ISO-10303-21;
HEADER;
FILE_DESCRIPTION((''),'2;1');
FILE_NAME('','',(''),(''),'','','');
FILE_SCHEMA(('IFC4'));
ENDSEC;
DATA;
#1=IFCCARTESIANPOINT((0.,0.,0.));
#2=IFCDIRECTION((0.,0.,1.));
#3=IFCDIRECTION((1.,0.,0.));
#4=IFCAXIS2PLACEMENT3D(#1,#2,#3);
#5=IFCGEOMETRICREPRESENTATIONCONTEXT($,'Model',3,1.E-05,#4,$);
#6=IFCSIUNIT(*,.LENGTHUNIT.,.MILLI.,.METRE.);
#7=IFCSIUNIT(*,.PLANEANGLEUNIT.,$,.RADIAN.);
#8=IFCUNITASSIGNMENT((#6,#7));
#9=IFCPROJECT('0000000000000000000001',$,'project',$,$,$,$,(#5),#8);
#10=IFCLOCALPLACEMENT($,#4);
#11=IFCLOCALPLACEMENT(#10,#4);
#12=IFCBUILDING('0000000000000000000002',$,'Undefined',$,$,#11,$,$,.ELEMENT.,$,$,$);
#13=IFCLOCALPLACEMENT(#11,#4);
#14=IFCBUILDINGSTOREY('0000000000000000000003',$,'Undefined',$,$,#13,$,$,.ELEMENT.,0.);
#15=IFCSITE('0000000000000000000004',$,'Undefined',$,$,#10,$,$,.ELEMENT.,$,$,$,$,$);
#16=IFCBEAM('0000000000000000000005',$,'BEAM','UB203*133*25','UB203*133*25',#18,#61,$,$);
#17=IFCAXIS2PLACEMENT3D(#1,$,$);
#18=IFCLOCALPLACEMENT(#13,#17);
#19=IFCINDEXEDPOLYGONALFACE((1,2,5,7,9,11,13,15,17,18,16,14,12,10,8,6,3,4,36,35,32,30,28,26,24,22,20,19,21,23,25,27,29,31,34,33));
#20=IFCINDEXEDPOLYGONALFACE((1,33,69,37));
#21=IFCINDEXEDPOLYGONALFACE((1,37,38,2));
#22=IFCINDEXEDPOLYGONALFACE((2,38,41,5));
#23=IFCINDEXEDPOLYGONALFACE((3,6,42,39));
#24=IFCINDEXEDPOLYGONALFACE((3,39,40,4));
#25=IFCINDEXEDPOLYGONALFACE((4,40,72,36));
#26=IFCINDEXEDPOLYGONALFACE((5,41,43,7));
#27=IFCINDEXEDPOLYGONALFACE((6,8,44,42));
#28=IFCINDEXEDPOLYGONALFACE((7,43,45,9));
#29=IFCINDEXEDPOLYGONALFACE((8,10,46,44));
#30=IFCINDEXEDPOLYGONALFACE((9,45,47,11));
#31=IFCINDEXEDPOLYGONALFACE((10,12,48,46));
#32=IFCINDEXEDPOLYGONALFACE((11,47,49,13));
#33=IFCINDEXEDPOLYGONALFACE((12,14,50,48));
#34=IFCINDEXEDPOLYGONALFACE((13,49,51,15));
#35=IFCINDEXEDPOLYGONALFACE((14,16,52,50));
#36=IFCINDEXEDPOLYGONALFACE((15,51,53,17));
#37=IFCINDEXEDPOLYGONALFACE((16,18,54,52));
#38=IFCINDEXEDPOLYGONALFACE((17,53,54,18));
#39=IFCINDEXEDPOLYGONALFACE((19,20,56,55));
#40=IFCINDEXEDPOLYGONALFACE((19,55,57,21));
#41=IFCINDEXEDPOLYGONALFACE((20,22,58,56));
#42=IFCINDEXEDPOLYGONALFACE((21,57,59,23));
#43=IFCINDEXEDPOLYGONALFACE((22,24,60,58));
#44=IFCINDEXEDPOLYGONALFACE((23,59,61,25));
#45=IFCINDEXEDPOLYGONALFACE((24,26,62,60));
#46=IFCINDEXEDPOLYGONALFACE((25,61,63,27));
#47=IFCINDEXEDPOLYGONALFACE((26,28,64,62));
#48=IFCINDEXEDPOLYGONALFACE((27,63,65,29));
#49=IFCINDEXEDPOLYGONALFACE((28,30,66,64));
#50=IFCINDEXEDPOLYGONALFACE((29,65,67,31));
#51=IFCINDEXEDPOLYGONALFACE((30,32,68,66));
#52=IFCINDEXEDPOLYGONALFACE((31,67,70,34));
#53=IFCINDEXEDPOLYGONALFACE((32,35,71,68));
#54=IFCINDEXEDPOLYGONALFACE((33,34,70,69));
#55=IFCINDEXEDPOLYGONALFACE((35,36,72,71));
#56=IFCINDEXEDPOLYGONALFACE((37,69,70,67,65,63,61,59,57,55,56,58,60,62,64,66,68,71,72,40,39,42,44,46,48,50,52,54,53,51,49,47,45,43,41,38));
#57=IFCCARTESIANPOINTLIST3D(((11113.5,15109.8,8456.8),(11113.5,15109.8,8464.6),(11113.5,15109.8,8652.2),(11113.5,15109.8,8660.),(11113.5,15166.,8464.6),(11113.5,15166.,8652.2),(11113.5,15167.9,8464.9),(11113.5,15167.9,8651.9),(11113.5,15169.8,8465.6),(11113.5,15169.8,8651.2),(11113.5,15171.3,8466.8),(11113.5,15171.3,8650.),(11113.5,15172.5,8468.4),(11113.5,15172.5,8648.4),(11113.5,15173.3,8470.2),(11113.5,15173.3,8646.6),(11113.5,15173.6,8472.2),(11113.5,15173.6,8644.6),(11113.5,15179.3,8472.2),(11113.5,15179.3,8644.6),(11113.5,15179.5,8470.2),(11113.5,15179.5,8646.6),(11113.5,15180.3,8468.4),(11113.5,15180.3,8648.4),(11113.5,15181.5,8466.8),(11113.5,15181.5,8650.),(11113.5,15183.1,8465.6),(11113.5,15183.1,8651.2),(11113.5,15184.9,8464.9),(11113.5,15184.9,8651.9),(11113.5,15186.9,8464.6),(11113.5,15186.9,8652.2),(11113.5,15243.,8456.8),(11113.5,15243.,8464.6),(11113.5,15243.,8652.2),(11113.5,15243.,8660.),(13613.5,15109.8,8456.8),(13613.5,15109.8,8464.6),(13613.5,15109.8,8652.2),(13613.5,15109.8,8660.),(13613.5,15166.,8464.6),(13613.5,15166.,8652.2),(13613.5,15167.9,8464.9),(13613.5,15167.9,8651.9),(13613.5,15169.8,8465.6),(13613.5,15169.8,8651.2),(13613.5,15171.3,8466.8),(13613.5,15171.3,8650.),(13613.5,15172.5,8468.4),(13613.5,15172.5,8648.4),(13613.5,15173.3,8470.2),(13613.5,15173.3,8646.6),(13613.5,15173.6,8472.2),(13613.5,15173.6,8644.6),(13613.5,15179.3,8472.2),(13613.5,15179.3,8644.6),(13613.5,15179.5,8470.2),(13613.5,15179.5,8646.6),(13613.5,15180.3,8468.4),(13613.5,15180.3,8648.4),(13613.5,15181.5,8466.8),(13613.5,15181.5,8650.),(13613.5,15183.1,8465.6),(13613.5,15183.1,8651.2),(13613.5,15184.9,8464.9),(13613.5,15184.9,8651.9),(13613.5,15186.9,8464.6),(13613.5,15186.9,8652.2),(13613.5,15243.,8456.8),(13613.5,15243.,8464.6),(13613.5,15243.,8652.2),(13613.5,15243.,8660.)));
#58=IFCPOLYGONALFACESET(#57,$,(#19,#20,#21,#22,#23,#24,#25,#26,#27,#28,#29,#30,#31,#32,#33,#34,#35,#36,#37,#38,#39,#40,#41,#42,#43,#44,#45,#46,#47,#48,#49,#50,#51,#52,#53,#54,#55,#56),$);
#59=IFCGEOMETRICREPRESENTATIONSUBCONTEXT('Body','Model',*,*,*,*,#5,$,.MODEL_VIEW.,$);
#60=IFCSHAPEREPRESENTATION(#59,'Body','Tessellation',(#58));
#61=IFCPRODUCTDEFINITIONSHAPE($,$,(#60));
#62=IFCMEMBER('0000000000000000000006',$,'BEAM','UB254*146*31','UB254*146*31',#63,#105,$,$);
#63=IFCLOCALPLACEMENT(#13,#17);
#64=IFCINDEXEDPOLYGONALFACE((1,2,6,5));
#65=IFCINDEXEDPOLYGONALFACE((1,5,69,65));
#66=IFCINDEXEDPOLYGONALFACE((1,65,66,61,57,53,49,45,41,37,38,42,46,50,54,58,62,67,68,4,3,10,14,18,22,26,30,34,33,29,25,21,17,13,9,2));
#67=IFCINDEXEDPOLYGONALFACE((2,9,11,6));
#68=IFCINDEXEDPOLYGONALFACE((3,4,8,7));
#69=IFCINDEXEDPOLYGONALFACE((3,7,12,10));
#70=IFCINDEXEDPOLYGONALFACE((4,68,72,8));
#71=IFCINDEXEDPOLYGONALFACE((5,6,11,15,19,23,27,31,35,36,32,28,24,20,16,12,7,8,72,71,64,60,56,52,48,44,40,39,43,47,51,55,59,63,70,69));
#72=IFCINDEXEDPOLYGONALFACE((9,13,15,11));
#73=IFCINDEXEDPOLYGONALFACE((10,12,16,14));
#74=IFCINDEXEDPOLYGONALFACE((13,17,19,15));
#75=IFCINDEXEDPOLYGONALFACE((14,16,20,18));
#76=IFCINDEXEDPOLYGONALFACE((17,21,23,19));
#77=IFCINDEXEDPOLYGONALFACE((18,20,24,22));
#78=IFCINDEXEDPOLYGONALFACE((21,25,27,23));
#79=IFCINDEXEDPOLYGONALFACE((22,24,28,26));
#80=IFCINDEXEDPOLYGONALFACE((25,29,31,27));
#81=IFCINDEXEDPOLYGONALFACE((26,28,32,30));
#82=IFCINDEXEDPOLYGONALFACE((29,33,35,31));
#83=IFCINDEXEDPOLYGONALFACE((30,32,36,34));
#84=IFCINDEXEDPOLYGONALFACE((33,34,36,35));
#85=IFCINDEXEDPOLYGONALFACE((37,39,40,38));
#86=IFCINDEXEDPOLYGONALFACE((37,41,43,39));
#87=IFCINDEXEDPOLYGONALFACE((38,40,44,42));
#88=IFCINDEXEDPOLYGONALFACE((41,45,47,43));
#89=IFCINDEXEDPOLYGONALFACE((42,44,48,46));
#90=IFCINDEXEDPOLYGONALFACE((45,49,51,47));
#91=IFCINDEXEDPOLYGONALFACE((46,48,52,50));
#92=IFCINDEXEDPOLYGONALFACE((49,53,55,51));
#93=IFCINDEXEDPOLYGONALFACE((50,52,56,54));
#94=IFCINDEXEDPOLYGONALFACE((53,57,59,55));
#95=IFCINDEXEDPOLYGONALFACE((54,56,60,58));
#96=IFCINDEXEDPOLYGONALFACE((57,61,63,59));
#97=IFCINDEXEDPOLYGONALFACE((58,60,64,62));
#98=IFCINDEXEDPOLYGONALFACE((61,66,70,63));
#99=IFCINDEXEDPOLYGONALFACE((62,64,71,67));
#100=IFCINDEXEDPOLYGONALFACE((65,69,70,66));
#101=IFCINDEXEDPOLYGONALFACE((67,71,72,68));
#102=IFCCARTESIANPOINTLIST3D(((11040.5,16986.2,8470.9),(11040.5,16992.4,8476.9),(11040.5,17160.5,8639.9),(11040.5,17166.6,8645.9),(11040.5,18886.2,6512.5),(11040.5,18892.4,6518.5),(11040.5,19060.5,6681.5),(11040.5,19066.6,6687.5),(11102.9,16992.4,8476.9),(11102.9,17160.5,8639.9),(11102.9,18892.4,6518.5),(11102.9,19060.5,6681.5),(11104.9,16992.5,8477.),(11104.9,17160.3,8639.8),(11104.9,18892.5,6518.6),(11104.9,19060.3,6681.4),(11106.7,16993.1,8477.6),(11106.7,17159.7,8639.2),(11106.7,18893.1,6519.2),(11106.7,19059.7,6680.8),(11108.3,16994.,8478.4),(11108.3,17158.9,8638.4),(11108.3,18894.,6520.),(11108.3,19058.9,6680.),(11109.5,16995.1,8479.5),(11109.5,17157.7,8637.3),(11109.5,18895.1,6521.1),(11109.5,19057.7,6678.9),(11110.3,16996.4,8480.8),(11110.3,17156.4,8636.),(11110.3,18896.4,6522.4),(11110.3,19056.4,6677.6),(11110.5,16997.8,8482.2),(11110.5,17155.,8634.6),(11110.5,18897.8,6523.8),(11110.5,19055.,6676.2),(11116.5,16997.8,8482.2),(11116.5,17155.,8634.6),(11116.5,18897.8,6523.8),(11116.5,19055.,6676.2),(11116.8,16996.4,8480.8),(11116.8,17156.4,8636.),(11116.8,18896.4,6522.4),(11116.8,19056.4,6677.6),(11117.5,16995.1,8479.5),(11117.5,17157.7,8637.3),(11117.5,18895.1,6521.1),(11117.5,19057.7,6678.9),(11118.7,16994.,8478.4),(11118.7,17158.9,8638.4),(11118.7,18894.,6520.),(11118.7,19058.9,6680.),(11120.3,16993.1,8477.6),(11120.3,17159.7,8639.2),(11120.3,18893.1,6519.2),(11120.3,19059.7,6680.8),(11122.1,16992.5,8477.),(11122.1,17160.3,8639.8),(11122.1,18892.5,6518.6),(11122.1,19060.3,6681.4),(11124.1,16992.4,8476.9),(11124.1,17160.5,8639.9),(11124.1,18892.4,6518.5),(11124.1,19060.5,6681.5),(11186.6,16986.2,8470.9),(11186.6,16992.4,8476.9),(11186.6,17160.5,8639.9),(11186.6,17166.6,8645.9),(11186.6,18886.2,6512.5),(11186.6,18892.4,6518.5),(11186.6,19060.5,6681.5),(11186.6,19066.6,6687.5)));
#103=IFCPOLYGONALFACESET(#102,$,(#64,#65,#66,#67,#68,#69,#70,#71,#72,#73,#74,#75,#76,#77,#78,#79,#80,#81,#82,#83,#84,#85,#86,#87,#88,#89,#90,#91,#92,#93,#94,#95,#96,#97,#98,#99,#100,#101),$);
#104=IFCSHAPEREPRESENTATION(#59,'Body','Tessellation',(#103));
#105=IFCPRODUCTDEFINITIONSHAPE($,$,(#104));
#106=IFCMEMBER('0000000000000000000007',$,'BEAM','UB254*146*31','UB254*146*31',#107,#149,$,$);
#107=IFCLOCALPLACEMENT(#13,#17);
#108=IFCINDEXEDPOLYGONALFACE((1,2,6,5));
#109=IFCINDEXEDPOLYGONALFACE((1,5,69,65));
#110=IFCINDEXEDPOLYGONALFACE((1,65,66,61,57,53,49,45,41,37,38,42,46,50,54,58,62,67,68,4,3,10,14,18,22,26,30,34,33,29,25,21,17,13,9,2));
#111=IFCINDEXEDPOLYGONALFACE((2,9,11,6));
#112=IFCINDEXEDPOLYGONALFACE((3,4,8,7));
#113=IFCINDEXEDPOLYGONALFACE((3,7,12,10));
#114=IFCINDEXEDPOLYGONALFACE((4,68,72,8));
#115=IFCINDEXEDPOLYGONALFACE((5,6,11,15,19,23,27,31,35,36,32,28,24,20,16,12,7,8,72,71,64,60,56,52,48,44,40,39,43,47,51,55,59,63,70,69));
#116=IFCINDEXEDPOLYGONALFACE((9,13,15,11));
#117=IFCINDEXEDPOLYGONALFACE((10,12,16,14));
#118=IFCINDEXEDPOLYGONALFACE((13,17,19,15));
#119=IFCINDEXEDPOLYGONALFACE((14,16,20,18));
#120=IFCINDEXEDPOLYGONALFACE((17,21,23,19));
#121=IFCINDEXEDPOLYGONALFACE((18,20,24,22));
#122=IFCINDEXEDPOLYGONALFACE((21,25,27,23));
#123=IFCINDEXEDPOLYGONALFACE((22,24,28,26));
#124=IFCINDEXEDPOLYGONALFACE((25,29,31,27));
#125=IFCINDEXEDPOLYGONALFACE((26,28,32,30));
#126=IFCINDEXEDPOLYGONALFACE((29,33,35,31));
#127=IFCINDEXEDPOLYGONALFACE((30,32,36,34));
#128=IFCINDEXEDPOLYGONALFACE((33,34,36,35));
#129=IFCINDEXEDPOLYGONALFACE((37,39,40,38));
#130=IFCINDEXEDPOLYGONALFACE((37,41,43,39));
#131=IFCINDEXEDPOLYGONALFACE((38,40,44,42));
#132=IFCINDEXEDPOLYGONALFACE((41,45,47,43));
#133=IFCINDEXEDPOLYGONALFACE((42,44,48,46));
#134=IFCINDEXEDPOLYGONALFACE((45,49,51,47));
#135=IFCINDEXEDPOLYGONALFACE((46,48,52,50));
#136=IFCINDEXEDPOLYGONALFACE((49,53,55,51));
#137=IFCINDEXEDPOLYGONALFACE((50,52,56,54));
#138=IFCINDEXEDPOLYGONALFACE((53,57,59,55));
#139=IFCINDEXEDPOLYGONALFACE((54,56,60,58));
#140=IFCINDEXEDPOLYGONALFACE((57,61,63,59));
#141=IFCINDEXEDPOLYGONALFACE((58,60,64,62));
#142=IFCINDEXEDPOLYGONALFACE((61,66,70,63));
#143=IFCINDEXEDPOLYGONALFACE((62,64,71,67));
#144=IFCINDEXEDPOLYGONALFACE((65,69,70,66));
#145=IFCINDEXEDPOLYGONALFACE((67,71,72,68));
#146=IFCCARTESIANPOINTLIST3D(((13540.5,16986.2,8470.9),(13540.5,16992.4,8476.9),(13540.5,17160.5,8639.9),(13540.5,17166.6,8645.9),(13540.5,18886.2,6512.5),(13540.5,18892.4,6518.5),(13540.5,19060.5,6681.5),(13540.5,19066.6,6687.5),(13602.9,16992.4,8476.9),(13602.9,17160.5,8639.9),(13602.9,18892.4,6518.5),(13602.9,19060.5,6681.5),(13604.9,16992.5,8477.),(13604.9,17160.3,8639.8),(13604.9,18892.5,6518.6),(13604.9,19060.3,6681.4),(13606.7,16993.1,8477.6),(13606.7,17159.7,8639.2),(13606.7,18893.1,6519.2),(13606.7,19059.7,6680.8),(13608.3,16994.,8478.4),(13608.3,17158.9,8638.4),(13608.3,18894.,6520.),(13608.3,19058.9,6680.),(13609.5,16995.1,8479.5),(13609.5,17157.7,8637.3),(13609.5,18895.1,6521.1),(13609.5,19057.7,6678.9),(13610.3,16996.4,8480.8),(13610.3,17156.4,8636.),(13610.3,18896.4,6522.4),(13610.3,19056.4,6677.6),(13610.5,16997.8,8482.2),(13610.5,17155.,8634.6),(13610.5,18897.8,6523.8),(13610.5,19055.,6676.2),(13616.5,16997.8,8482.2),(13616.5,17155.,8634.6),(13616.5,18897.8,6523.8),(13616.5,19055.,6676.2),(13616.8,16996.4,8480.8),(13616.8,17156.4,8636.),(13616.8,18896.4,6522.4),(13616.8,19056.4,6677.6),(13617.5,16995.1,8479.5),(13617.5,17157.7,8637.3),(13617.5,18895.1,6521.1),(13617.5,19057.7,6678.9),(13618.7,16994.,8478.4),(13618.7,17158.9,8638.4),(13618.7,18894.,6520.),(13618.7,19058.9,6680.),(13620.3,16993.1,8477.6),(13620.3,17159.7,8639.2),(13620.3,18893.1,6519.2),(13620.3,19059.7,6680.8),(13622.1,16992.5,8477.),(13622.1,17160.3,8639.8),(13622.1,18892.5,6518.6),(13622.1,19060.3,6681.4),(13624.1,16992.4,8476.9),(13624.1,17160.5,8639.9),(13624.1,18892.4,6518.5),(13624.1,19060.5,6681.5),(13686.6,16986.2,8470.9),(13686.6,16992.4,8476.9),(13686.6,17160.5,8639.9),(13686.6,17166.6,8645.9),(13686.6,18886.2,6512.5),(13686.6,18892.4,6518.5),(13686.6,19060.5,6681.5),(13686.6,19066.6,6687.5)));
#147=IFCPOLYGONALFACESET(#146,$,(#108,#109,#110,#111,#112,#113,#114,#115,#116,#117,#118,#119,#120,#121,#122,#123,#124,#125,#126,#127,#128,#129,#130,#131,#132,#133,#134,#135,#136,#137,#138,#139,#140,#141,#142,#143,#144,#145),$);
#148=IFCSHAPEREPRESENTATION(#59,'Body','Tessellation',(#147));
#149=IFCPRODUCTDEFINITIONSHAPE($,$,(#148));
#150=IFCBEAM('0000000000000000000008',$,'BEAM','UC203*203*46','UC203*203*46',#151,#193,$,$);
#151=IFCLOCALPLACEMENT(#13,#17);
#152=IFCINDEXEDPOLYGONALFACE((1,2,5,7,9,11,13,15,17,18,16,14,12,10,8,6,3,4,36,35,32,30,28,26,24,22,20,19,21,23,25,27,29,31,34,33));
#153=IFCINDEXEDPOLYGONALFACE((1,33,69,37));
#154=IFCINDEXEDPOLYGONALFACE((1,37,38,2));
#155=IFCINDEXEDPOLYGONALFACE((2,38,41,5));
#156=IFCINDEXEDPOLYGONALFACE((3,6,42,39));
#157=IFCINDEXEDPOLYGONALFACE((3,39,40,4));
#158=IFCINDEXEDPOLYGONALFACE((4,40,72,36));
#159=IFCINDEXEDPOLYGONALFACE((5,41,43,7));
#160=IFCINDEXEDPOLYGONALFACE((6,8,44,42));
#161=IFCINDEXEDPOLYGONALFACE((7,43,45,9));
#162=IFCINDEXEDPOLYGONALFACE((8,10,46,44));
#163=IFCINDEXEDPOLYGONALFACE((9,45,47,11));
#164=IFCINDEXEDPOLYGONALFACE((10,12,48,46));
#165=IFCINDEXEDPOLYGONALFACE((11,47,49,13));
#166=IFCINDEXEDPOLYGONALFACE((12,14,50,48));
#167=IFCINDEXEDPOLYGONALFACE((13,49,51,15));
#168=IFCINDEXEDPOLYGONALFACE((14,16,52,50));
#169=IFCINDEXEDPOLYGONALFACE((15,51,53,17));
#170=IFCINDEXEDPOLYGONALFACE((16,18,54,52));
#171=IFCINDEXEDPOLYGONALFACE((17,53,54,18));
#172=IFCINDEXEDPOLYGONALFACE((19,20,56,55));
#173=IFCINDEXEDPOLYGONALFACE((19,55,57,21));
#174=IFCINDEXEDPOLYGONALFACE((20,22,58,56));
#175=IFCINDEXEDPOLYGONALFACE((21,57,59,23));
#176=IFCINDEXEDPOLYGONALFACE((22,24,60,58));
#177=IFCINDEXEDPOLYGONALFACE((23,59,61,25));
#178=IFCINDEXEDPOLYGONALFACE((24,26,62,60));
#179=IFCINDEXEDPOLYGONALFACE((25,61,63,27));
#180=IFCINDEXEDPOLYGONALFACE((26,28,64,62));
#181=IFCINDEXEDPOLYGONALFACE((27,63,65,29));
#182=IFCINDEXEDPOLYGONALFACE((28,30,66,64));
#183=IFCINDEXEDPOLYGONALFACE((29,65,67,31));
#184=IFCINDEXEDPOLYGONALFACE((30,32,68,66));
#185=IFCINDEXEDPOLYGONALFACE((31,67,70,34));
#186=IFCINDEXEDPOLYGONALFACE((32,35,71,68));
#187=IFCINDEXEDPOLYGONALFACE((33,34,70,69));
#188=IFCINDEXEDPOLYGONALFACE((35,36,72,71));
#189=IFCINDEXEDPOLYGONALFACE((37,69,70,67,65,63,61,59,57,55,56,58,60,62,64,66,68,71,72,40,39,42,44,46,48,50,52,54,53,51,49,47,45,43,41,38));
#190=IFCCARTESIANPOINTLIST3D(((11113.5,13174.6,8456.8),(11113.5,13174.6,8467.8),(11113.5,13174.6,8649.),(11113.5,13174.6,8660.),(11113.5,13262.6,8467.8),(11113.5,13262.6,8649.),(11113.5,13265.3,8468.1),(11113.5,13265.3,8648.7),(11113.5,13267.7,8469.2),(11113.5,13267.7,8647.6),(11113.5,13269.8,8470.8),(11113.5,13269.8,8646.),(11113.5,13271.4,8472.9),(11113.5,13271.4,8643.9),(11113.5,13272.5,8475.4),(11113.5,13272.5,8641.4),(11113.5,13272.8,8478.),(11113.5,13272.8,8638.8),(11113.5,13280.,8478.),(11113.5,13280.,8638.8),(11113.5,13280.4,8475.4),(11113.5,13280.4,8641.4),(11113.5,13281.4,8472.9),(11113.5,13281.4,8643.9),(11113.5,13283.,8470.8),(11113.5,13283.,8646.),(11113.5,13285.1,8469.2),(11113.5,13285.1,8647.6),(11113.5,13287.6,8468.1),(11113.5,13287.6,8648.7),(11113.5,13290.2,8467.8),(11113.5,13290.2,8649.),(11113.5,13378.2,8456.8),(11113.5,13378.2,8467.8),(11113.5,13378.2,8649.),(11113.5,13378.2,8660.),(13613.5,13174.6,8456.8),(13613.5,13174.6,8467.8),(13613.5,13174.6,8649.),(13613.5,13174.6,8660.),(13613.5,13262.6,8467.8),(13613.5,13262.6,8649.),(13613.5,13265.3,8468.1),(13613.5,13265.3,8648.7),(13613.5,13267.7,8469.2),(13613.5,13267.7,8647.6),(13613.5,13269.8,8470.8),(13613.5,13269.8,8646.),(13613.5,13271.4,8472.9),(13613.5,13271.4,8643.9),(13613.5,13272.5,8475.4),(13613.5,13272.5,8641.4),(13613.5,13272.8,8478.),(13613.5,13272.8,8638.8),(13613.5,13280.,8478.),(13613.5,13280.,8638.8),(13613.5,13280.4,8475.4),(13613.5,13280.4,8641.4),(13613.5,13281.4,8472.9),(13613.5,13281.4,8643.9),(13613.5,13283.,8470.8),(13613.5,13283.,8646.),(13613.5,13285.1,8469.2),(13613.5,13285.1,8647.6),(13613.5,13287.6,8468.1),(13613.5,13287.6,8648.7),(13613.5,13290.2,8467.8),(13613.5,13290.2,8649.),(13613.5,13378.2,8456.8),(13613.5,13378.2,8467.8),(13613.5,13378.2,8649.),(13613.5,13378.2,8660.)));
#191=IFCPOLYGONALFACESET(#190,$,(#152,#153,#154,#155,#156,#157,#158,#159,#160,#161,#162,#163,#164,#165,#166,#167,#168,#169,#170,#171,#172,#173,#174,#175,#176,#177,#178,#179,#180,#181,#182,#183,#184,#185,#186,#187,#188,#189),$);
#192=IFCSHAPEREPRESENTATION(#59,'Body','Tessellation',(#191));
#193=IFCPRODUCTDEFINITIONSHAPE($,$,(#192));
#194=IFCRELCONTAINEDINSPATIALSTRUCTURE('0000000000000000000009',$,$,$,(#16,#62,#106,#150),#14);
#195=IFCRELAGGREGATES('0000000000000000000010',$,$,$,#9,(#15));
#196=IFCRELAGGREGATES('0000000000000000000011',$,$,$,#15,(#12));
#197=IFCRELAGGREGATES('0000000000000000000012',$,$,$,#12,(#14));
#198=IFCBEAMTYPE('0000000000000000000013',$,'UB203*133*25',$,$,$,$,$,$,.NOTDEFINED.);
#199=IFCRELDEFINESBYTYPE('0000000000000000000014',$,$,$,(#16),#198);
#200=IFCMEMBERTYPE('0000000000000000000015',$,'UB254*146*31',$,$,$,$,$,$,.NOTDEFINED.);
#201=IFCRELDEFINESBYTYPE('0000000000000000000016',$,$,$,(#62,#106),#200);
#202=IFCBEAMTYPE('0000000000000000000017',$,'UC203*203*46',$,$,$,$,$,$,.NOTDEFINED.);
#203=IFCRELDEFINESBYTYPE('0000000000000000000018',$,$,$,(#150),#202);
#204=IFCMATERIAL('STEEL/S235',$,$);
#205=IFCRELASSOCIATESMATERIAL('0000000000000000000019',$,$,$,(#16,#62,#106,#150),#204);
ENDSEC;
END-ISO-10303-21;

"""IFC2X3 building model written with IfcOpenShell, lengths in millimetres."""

from ifc_helpers import new_model, si_unit, frame, origin_with_axes, origin_2d_with_axis, place, context, subcontext, project, spatial, i_section, extrude, material, type_object, element, save


model = new_model("IFC2X3")

# Units and contexts
model_context = context("Model", 3, precision=1e-05, world=origin_with_axes())
body_context = subcontext(model_context, "Body", "Model", "MODEL_VIEW")
ifc_project = project(units=[si_unit("LENGTHUNIT", "METRE", prefix="MILLI"), si_unit("PLANEANGLEUNIT", "RADIAN")], contexts=[model_context])

# Site, building, storey
site_placement = place(None, origin_with_axes())
site = spatial("IfcSite", under=ifc_project, at=site_placement, Name="Undefined", CompositionType="ELEMENT")
building_placement = place(site_placement, origin_with_axes())
building = spatial("IfcBuilding", under=site, at=building_placement, Name="Undefined", CompositionType="ELEMENT")
storey_placement = place(building_placement, origin_with_axes())
storey = spatial("IfcBuildingStorey", under=building, at=storey_placement, Name="Undefined", CompositionType="ELEMENT", Elevation=0.0)

# Shared definitions
ifc_material = material(Name="STEEL/S235")

# Beam
beam_type_1 = type_object("IfcBeamType", Name="UB203*133*25", PredefinedType="NOTDEFINED")
for number, where, z_axis, x_axis, name in (
    (1, (11113.5, 15176.4, 8558.4), (0.0, 0.0, 1.0), (1.0, 0.0, 0.0), "BEAM"),
):
    element("IfcBeam", number, at=place(storey_placement, frame(where, z_axis=z_axis, x_axis=x_axis)), inside=storey, type_object=beam_type_1, material=ifc_material, Name=name, Description="UB203*133*25", ObjectType="UB203*133*25", context=body_context, shape_type="SweptSolid", body=[
        extrude(i_section(OverallWidth=133.2, OverallDepth=203.2, WebThickness=5.7, FlangeThickness=7.8, FilletRadius=7.6, at=origin_2d_with_axis()), frame((2500.0, 0.0, 0.0), z_axis=(-1.0, 0.0, 0.0), x_axis=(0.0, -1.0, 0.0)), (0.0, 0.0, 1.0), 2500.0),
    ])

# Members
member_type_1 = type_object("IfcMemberType", Name="UB254*146*31", PredefinedType="NOTDEFINED")
for number, where, z_axis, x_axis, name in (
    (2, (11113.5, 18976.4, 6600.0), (0.0, 0.717727, 0.696324), (0.0, -0.696324, 0.717727), "BEAM"),
    (3, (13613.5, 18976.4, 6600.0), (0.0, 0.717727, 0.696324), (0.0, -0.696324, 0.717727), "BEAM"),
):
    element("IfcMember", number, at=place(storey_placement, frame(where, z_axis=z_axis, x_axis=x_axis)), inside=storey, type_object=member_type_1, material=ifc_material, Name=name, Description="UB254*146*31", ObjectType="UB254*146*31", context=body_context, shape_type="SweptSolid", body=[
        extrude(i_section(OverallWidth=146.1, OverallDepth=251.4, WebThickness=6.0, FlangeThickness=8.6, FilletRadius=7.6, at=origin_2d_with_axis()), frame((2728.6, 0.0, 0.0), z_axis=(-1.0, 0.0, 0.0), x_axis=(0.0, -1.0, 0.0)), (0.0, 0.0, 1.0), 2728.6),
    ])

# Beam
beam_type_2 = type_object("IfcBeamType", Name="UC203*203*46", PredefinedType="NOTDEFINED")
beam_placement = place(storey_placement, frame((11113.5, 13276.4, 8558.4), z_axis=(0.0, 0.0, 1.0), x_axis=(1.0, 0.0, 0.0)))
element("IfcBeam", 4, at=beam_placement, inside=storey, type_object=beam_type_2, material=ifc_material, Name="BEAM", Description="UC203*203*46", ObjectType="UC203*203*46", context=body_context, shape_type="SweptSolid", body=[
    extrude(i_section(OverallWidth=203.6, OverallDepth=203.2, WebThickness=7.2, FlangeThickness=11.0, FilletRadius=10.2, at=origin_2d_with_axis()), frame((2500.0, 0.0, 0.0), z_axis=(-1.0, 0.0, 0.0), x_axis=(0.0, -1.0, 0.0)), (0.0, 0.0, 1.0), 2500.0),
])

save(model, "model.ifc")
